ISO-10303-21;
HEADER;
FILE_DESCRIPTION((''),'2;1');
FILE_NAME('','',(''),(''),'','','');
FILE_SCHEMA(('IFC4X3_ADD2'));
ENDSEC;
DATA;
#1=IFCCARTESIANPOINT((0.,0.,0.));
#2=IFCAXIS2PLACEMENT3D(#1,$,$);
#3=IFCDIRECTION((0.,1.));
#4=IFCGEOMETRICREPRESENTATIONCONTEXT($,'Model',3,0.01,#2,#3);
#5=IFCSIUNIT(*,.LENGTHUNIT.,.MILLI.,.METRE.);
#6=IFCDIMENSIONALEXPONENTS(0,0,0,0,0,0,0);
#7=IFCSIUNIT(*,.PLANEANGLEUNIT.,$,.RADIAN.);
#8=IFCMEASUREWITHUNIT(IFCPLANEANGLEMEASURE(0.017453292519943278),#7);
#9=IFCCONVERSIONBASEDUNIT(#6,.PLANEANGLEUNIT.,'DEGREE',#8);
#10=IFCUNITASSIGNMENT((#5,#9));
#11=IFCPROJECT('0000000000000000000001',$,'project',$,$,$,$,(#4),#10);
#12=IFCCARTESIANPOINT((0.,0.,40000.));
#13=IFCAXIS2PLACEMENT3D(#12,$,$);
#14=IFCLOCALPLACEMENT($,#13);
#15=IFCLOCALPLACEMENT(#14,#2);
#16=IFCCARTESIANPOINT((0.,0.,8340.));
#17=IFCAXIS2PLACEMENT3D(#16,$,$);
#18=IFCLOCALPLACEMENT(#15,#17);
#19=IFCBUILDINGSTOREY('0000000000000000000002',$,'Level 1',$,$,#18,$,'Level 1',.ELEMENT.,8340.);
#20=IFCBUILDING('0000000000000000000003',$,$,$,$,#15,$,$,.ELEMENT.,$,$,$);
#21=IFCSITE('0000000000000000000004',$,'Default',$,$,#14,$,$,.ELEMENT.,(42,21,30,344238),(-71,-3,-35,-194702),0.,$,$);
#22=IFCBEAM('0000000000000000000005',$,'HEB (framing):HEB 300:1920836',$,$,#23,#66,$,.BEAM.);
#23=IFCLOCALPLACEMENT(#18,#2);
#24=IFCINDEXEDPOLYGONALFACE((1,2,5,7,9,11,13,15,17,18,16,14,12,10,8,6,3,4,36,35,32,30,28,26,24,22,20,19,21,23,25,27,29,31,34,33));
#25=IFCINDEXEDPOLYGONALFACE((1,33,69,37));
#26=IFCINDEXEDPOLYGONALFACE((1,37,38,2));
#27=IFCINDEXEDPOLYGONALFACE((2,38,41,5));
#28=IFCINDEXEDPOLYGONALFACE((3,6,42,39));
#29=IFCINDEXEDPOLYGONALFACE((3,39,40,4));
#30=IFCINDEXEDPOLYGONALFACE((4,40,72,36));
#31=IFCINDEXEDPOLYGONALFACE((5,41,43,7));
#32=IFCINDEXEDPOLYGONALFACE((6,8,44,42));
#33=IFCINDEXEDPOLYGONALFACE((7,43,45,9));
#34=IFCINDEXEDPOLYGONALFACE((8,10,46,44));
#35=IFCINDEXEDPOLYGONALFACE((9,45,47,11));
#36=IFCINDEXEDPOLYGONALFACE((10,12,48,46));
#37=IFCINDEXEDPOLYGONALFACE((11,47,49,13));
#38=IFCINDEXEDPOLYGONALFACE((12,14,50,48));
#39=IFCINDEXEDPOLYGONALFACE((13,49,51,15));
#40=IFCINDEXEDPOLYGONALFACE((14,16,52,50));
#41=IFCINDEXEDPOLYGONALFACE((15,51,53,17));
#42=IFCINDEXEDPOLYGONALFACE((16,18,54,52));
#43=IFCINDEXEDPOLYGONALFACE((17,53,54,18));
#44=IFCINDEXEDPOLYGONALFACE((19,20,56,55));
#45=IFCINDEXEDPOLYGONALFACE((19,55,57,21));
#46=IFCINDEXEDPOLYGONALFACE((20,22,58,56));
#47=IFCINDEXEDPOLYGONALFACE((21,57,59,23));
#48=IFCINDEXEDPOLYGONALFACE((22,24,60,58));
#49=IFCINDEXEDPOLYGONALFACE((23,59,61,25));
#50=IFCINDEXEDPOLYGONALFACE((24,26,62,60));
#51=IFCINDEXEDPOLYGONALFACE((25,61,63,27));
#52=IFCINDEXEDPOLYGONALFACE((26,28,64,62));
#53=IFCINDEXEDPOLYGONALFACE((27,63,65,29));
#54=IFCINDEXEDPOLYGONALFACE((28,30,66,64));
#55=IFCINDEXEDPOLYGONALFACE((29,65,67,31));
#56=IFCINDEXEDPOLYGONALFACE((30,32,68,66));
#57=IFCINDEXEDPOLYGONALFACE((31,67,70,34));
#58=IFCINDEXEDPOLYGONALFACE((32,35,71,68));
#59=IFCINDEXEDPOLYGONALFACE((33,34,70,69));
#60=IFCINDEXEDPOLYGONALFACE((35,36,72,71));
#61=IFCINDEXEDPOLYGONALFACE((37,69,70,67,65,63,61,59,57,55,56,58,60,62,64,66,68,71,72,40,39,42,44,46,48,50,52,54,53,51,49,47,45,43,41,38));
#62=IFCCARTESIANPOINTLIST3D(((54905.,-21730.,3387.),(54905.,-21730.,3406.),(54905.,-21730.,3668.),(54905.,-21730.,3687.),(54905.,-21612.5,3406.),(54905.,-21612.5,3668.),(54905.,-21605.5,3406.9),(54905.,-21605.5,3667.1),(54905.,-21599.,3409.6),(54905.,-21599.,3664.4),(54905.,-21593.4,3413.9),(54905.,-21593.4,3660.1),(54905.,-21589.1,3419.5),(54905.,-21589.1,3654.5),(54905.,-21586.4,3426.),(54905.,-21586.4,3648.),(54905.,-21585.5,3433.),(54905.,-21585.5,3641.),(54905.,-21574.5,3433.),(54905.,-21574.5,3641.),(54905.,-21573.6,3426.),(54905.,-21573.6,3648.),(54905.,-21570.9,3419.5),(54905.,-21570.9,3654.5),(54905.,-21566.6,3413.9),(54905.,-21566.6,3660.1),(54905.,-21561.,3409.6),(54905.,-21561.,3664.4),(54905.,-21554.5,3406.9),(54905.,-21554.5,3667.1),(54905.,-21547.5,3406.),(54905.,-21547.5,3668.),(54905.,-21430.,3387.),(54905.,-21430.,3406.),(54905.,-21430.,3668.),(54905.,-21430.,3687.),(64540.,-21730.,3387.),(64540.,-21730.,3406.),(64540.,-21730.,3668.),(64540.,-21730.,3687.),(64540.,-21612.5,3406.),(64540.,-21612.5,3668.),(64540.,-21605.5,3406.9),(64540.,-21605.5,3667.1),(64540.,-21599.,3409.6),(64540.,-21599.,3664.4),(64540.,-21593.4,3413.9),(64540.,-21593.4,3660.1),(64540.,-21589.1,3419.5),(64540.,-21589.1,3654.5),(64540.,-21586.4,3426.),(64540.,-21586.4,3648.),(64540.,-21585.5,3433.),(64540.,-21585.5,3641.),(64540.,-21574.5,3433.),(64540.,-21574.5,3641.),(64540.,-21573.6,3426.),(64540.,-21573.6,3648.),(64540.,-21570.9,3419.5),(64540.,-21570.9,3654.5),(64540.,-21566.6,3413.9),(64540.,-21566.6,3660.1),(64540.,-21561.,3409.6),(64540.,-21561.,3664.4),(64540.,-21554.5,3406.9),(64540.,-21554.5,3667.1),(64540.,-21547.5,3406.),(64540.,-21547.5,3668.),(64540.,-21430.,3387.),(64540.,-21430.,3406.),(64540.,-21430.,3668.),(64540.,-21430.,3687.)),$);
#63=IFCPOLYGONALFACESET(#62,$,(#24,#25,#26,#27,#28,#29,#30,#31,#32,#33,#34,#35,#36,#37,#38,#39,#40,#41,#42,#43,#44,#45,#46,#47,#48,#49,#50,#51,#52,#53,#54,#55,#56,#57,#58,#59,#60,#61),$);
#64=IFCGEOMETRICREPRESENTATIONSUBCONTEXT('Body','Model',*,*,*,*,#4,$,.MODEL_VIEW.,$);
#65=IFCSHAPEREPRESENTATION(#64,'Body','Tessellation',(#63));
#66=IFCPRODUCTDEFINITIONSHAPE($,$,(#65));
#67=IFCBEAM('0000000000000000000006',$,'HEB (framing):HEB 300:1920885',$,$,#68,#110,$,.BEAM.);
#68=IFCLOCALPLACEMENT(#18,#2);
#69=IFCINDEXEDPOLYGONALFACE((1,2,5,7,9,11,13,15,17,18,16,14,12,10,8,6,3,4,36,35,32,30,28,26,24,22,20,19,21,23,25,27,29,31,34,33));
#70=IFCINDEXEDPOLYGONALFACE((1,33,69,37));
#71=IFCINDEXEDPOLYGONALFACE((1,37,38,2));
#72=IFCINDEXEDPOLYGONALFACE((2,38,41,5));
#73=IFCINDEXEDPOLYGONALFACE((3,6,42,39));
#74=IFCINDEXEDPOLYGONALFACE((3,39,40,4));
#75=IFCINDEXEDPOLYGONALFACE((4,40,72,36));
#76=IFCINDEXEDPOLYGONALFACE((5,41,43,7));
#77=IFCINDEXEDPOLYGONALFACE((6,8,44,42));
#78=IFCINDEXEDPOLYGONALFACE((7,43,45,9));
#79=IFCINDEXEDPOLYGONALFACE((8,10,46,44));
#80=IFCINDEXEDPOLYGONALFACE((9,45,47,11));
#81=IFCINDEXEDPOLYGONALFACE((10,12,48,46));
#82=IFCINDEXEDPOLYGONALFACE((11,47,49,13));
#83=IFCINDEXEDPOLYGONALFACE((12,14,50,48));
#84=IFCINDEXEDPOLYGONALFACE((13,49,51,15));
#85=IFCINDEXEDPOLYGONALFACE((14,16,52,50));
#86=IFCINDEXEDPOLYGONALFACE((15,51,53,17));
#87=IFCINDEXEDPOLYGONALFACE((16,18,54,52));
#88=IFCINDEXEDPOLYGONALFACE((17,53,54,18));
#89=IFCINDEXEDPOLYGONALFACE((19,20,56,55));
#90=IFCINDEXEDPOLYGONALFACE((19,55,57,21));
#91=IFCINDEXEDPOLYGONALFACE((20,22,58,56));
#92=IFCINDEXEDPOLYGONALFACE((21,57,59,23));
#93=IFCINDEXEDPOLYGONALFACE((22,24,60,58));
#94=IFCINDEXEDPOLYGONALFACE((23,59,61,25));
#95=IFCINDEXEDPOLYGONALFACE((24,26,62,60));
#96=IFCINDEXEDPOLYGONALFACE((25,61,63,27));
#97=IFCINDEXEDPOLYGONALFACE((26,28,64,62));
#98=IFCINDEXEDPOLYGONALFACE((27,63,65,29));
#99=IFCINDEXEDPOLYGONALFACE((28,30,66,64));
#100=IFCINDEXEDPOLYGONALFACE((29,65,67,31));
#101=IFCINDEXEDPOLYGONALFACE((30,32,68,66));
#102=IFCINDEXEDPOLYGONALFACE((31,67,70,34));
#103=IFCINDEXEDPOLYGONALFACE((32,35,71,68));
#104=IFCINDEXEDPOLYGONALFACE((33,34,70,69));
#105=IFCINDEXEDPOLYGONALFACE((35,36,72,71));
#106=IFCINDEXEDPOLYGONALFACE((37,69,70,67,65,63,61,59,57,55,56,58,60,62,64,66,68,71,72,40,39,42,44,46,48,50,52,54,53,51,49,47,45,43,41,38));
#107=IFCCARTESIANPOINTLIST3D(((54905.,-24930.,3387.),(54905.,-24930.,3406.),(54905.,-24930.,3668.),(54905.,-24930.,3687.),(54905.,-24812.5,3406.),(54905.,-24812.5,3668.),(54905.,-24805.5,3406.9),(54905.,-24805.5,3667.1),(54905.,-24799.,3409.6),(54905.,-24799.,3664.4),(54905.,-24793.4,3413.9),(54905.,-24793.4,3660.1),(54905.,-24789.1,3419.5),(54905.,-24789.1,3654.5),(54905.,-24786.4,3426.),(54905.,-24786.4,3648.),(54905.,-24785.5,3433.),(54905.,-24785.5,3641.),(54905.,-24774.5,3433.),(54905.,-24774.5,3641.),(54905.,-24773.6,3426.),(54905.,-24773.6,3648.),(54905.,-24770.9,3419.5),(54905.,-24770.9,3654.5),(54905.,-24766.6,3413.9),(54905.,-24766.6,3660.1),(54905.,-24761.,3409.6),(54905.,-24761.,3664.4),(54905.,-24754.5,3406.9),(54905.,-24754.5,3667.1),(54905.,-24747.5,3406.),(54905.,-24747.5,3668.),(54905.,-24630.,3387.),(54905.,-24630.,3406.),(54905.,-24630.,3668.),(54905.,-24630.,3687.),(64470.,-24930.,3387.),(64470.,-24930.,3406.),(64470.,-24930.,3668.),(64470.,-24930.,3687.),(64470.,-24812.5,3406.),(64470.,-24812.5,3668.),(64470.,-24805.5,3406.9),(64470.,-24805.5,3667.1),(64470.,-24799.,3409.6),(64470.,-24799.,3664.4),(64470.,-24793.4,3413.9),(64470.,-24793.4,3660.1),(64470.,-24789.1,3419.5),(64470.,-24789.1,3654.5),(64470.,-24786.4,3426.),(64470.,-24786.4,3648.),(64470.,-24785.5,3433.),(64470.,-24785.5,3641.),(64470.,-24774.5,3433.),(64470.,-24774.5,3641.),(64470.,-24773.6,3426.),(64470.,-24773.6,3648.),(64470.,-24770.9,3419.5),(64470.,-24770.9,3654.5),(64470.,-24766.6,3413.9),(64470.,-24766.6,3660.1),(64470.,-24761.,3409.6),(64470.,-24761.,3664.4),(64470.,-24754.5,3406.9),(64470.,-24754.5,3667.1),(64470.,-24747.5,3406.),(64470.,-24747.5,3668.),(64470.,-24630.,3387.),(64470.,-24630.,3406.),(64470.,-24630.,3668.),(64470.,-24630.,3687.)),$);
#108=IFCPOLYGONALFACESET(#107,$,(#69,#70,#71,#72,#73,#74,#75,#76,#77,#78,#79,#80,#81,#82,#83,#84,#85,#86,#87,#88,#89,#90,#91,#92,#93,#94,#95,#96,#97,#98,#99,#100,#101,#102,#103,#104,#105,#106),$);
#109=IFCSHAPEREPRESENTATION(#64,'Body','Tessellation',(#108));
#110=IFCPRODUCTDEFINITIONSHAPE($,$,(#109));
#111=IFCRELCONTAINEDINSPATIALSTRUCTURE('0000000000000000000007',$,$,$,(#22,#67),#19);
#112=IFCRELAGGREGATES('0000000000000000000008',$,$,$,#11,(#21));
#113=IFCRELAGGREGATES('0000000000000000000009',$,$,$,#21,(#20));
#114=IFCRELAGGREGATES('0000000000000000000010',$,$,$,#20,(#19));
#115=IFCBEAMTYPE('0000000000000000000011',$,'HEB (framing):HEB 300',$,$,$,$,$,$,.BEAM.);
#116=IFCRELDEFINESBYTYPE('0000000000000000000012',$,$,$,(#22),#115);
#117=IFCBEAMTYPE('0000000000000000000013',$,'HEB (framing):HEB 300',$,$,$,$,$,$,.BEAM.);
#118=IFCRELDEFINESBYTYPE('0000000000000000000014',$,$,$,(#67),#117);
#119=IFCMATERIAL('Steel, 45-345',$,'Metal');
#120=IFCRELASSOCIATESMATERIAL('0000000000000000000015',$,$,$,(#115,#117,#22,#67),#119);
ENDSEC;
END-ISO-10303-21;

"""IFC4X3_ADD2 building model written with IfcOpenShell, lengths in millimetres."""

from ifc_helpers import new_model, entity, si_unit, converted_unit, direction, frame, frame_2d, origin, place, context, subcontext, project, spatial, polyline, circle_curve, parameter, trimmed, segment, composite_curve, outline, extrude, source, transform, mapped, material, material_profile, profile_set, profile_usage, type_object, type_shapes, element, save


model = new_model("IFC4X3_ADD2")

# Units and contexts
model_context = context("Model", 3, precision=0.01, world=origin(), true_north=direction((0.0, 1.0)))
body_context = subcontext(model_context, "Body", "Model", "MODEL_VIEW")
ifc_project = project(units=[si_unit("LENGTHUNIT", "METRE", prefix="MILLI"), converted_unit("PLANEANGLEUNIT", "DEGREE", entity("IfcPlaneAngleMeasure", 0.017453292519943278), si_unit("PLANEANGLEUNIT", "RADIAN"), dimensions=[0, 0, 0, 0, 0, 0, 0])], contexts=[model_context])

# Site, building, storey
site_placement = place(None, frame((0.0, 0.0, 40000.0)))
site = spatial("IfcSite", under=ifc_project, at=site_placement, Name="Default", CompositionType="ELEMENT", RefLatitude=(42, 21, 30, 344238), RefLongitude=(-71, -3, -35, -194702), RefElevation=0.0)
building_placement = place(site_placement, origin())
building = spatial("IfcBuilding", under=site, at=building_placement, CompositionType="ELEMENT")
storey_placement = place(building_placement, frame((0.0, 0.0, 8340.0)))
storey = spatial("IfcBuildingStorey", under=building, at=storey_placement, Name="Level 1", LongName="Level 1", CompositionType="ELEMENT", Elevation=8340.0)

# Shared definitions
ifc_material_1 = material(Name="Steel, 45-345", Category="Metal")

# Beams
ifc_material_profile_1 = material_profile(ifc_material_1, outline(composite_curve([segment(polyline([(-150.0, -131.0), (-150.0, -150.0)]), True, "CONTINUOUS"), segment(polyline([(-150.0, -150.0), (150.0, -150.0)]), True, "CONTINUOUS"), segment(polyline([(150.0, -150.0), (150.0, -131.0)]), True, "CONTINUOUS"), segment(polyline([(150.0, -131.0), (32.5, -131.0)]), True, "CONTINUOUS"), segment(trimmed(circle_curve(frame_2d((32.5, -104.0), x_axis=(1.0, 0.0)), 27.0), [parameter(180.0)], [parameter(270.0)], True, "PARAMETER"), False, "CONTINUOUS"), segment(polyline([(5.5, -104.0), (5.5, 104.0)]), True, "CONTINUOUS"), segment(trimmed(circle_curve(frame_2d((32.5, 104.0), x_axis=(1.0, 0.0)), 27.0), [parameter(90.0)], [parameter(180.0)], True, "PARAMETER"), False, "CONTINUOUS"), segment(polyline([(32.5, 131.0), (150.0, 131.0)]), True, "CONTINUOUS"), segment(polyline([(150.0, 131.0), (150.0, 150.0)]), True, "CONTINUOUS"), segment(polyline([(150.0, 150.0), (-150.0, 150.0)]), True, "CONTINUOUS"), segment(polyline([(-150.0, 150.0), (-150.0, 131.0)]), True, "CONTINUOUS"), segment(polyline([(-150.0, 131.0), (-32.5, 131.0)]), True, "CONTINUOUS"), segment(trimmed(circle_curve(frame_2d((-32.5, 104.0), x_axis=(1.0, 0.0)), 27.0), [parameter(360.0)], [parameter(90.0)], True, "PARAMETER"), False, "CONTINUOUS"), segment(polyline([(-5.5, 104.0), (-5.5, -104.0)]), True, "CONTINUOUS"), segment(trimmed(circle_curve(frame_2d((-32.5, -104.0), x_axis=(1.0, 0.0)), 27.0), [parameter(270.0)], [parameter(0.0)], True, "PARAMETER"), False, "CONTINUOUS"), segment(polyline([(-32.5, -131.0), (-150.0, -131.0)]), True, "CONTINUOUS")], self_intersect=False)), Name="HEB 300")
ifc_profile_set_1 = profile_set([ifc_material_profile_1], Name="HEB 300")
ifc_profile_usage_1 = profile_usage(ifc_profile_set_1, cardinal=8)
beam_type_1 = type_object("IfcBeamType", Name="HEB (framing):HEB 300", PredefinedType="BEAM", material=ifc_profile_set_1)
shared_shape_1 = source(origin(), body_context, "Body", "SweptSolid", [
    extrude(outline(composite_curve([segment(polyline([(-150.0, -131.0), (-150.0, -150.0)]), True, "CONTINUOUS"), segment(polyline([(-150.0, -150.0), (150.0, -150.0)]), True, "CONTINUOUS"), segment(polyline([(150.0, -150.0), (150.0, -131.0)]), True, "CONTINUOUS"), segment(polyline([(150.0, -131.0), (32.5, -131.0)]), True, "CONTINUOUS"), segment(trimmed(circle_curve(frame_2d((32.5, -104.0), x_axis=(1.0, 0.0)), 27.0), [parameter(180.0)], [parameter(270.0)], True, "PARAMETER"), False, "CONTINUOUS"), segment(polyline([(5.5, -104.0), (5.5, 104.0)]), True, "CONTINUOUS"), segment(trimmed(circle_curve(frame_2d((32.5, 104.0), x_axis=(1.0, 0.0)), 27.0), [parameter(90.0)], [parameter(180.0)], True, "PARAMETER"), False, "CONTINUOUS"), segment(polyline([(32.5, 131.0), (150.0, 131.0)]), True, "CONTINUOUS"), segment(polyline([(150.0, 131.0), (150.0, 150.0)]), True, "CONTINUOUS"), segment(polyline([(150.0, 150.0), (-150.0, 150.0)]), True, "CONTINUOUS"), segment(polyline([(-150.0, 150.0), (-150.0, 131.0)]), True, "CONTINUOUS"), segment(polyline([(-150.0, 131.0), (-32.5, 131.0)]), True, "CONTINUOUS"), segment(trimmed(circle_curve(frame_2d((-32.5, 104.0), x_axis=(1.0, 0.0)), 27.0), [parameter(360.0)], [parameter(90.0)], True, "PARAMETER"), False, "CONTINUOUS"), segment(polyline([(-5.5, 104.0), (-5.5, -104.0)]), True, "CONTINUOUS"), segment(trimmed(circle_curve(frame_2d((-32.5, -104.0), x_axis=(1.0, 0.0)), 27.0), [parameter(270.0)], [parameter(0.0)], True, "PARAMETER"), False, "CONTINUOUS"), segment(polyline([(-32.5, -131.0), (-150.0, -131.0)]), True, "CONTINUOUS")], self_intersect=False)), frame((-4782.5, 0.0, 0.0), z_axis=(-1.0, 0.0, 0.0), x_axis=(0.0, -1.0, 0.0)), (0.0, 0.0, -1.0), 9635.0),
])
type_shapes(beam_type_1, [shared_shape_1])
for number, where, name in (
    (1, (59687.5, -21580.0, 3537.0), "HEB (framing):HEB 300:1920836"),
):
    element("IfcBeam", number, at=place(storey_placement, frame(where)), inside=storey, type_object=beam_type_1, material=ifc_profile_usage_1, Name=name, PredefinedType="BEAM", context=body_context, shape_type="MappedRepresentation", body=[
        mapped(shared_shape_1, transform((0.0, 0.0, 0.0), scale=1.0)),
    ])
beam_type_2 = type_object("IfcBeamType", Name="HEB (framing):HEB 300", PredefinedType="BEAM", material=ifc_profile_set_1)
shared_shape_2 = source(origin(), body_context, "Body", "SweptSolid", [
    extrude(outline(composite_curve([segment(polyline([(-150.0, -131.0), (-150.0, -150.0)]), True, "CONTINUOUS"), segment(polyline([(-150.0, -150.0), (150.0, -150.0)]), True, "CONTINUOUS"), segment(polyline([(150.0, -150.0), (150.0, -131.0)]), True, "CONTINUOUS"), segment(polyline([(150.0, -131.0), (32.5, -131.0)]), True, "CONTINUOUS"), segment(trimmed(circle_curve(frame_2d((32.5, -104.0), x_axis=(1.0, 0.0)), 27.0), [parameter(180.0)], [parameter(270.0)], True, "PARAMETER"), False, "CONTINUOUS"), segment(polyline([(5.5, -104.0), (5.5, 104.0)]), True, "CONTINUOUS"), segment(trimmed(circle_curve(frame_2d((32.5, 104.0), x_axis=(1.0, 0.0)), 27.0), [parameter(90.0)], [parameter(180.0)], True, "PARAMETER"), False, "CONTINUOUS"), segment(polyline([(32.5, 131.0), (150.0, 131.0)]), True, "CONTINUOUS"), segment(polyline([(150.0, 131.0), (150.0, 150.0)]), True, "CONTINUOUS"), segment(polyline([(150.0, 150.0), (-150.0, 150.0)]), True, "CONTINUOUS"), segment(polyline([(-150.0, 150.0), (-150.0, 131.0)]), True, "CONTINUOUS"), segment(polyline([(-150.0, 131.0), (-32.5, 131.0)]), True, "CONTINUOUS"), segment(trimmed(circle_curve(frame_2d((-32.5, 104.0), x_axis=(1.0, 0.0)), 27.0), [parameter(360.0)], [parameter(90.0)], True, "PARAMETER"), False, "CONTINUOUS"), segment(polyline([(-5.5, 104.0), (-5.5, -104.0)]), True, "CONTINUOUS"), segment(trimmed(circle_curve(frame_2d((-32.5, -104.0), x_axis=(1.0, 0.0)), 27.0), [parameter(270.0)], [parameter(0.0)], True, "PARAMETER"), False, "CONTINUOUS"), segment(polyline([(-32.5, -131.0), (-150.0, -131.0)]), True, "CONTINUOUS")], self_intersect=False)), frame((-4697.5, 0.0, 0.0), z_axis=(-1.0, 0.0, 0.0), x_axis=(0.0, -1.0, 0.0)), (0.0, 0.0, -1.0), 9565.0),
])
type_shapes(beam_type_2, [shared_shape_2])
beam_1_placement = place(storey_placement, frame((59602.5, -24780.0, 3537.0)))
element("IfcBeam", 2, at=beam_1_placement, inside=storey, type_object=beam_type_2, material=ifc_profile_usage_1, Name="HEB (framing):HEB 300:1920885", PredefinedType="BEAM", context=body_context, shape_type="MappedRepresentation", body=[
    mapped(shared_shape_2, transform((0.0, 0.0, 0.0), scale=1.0)),
])

save(model, "model.ifc")
